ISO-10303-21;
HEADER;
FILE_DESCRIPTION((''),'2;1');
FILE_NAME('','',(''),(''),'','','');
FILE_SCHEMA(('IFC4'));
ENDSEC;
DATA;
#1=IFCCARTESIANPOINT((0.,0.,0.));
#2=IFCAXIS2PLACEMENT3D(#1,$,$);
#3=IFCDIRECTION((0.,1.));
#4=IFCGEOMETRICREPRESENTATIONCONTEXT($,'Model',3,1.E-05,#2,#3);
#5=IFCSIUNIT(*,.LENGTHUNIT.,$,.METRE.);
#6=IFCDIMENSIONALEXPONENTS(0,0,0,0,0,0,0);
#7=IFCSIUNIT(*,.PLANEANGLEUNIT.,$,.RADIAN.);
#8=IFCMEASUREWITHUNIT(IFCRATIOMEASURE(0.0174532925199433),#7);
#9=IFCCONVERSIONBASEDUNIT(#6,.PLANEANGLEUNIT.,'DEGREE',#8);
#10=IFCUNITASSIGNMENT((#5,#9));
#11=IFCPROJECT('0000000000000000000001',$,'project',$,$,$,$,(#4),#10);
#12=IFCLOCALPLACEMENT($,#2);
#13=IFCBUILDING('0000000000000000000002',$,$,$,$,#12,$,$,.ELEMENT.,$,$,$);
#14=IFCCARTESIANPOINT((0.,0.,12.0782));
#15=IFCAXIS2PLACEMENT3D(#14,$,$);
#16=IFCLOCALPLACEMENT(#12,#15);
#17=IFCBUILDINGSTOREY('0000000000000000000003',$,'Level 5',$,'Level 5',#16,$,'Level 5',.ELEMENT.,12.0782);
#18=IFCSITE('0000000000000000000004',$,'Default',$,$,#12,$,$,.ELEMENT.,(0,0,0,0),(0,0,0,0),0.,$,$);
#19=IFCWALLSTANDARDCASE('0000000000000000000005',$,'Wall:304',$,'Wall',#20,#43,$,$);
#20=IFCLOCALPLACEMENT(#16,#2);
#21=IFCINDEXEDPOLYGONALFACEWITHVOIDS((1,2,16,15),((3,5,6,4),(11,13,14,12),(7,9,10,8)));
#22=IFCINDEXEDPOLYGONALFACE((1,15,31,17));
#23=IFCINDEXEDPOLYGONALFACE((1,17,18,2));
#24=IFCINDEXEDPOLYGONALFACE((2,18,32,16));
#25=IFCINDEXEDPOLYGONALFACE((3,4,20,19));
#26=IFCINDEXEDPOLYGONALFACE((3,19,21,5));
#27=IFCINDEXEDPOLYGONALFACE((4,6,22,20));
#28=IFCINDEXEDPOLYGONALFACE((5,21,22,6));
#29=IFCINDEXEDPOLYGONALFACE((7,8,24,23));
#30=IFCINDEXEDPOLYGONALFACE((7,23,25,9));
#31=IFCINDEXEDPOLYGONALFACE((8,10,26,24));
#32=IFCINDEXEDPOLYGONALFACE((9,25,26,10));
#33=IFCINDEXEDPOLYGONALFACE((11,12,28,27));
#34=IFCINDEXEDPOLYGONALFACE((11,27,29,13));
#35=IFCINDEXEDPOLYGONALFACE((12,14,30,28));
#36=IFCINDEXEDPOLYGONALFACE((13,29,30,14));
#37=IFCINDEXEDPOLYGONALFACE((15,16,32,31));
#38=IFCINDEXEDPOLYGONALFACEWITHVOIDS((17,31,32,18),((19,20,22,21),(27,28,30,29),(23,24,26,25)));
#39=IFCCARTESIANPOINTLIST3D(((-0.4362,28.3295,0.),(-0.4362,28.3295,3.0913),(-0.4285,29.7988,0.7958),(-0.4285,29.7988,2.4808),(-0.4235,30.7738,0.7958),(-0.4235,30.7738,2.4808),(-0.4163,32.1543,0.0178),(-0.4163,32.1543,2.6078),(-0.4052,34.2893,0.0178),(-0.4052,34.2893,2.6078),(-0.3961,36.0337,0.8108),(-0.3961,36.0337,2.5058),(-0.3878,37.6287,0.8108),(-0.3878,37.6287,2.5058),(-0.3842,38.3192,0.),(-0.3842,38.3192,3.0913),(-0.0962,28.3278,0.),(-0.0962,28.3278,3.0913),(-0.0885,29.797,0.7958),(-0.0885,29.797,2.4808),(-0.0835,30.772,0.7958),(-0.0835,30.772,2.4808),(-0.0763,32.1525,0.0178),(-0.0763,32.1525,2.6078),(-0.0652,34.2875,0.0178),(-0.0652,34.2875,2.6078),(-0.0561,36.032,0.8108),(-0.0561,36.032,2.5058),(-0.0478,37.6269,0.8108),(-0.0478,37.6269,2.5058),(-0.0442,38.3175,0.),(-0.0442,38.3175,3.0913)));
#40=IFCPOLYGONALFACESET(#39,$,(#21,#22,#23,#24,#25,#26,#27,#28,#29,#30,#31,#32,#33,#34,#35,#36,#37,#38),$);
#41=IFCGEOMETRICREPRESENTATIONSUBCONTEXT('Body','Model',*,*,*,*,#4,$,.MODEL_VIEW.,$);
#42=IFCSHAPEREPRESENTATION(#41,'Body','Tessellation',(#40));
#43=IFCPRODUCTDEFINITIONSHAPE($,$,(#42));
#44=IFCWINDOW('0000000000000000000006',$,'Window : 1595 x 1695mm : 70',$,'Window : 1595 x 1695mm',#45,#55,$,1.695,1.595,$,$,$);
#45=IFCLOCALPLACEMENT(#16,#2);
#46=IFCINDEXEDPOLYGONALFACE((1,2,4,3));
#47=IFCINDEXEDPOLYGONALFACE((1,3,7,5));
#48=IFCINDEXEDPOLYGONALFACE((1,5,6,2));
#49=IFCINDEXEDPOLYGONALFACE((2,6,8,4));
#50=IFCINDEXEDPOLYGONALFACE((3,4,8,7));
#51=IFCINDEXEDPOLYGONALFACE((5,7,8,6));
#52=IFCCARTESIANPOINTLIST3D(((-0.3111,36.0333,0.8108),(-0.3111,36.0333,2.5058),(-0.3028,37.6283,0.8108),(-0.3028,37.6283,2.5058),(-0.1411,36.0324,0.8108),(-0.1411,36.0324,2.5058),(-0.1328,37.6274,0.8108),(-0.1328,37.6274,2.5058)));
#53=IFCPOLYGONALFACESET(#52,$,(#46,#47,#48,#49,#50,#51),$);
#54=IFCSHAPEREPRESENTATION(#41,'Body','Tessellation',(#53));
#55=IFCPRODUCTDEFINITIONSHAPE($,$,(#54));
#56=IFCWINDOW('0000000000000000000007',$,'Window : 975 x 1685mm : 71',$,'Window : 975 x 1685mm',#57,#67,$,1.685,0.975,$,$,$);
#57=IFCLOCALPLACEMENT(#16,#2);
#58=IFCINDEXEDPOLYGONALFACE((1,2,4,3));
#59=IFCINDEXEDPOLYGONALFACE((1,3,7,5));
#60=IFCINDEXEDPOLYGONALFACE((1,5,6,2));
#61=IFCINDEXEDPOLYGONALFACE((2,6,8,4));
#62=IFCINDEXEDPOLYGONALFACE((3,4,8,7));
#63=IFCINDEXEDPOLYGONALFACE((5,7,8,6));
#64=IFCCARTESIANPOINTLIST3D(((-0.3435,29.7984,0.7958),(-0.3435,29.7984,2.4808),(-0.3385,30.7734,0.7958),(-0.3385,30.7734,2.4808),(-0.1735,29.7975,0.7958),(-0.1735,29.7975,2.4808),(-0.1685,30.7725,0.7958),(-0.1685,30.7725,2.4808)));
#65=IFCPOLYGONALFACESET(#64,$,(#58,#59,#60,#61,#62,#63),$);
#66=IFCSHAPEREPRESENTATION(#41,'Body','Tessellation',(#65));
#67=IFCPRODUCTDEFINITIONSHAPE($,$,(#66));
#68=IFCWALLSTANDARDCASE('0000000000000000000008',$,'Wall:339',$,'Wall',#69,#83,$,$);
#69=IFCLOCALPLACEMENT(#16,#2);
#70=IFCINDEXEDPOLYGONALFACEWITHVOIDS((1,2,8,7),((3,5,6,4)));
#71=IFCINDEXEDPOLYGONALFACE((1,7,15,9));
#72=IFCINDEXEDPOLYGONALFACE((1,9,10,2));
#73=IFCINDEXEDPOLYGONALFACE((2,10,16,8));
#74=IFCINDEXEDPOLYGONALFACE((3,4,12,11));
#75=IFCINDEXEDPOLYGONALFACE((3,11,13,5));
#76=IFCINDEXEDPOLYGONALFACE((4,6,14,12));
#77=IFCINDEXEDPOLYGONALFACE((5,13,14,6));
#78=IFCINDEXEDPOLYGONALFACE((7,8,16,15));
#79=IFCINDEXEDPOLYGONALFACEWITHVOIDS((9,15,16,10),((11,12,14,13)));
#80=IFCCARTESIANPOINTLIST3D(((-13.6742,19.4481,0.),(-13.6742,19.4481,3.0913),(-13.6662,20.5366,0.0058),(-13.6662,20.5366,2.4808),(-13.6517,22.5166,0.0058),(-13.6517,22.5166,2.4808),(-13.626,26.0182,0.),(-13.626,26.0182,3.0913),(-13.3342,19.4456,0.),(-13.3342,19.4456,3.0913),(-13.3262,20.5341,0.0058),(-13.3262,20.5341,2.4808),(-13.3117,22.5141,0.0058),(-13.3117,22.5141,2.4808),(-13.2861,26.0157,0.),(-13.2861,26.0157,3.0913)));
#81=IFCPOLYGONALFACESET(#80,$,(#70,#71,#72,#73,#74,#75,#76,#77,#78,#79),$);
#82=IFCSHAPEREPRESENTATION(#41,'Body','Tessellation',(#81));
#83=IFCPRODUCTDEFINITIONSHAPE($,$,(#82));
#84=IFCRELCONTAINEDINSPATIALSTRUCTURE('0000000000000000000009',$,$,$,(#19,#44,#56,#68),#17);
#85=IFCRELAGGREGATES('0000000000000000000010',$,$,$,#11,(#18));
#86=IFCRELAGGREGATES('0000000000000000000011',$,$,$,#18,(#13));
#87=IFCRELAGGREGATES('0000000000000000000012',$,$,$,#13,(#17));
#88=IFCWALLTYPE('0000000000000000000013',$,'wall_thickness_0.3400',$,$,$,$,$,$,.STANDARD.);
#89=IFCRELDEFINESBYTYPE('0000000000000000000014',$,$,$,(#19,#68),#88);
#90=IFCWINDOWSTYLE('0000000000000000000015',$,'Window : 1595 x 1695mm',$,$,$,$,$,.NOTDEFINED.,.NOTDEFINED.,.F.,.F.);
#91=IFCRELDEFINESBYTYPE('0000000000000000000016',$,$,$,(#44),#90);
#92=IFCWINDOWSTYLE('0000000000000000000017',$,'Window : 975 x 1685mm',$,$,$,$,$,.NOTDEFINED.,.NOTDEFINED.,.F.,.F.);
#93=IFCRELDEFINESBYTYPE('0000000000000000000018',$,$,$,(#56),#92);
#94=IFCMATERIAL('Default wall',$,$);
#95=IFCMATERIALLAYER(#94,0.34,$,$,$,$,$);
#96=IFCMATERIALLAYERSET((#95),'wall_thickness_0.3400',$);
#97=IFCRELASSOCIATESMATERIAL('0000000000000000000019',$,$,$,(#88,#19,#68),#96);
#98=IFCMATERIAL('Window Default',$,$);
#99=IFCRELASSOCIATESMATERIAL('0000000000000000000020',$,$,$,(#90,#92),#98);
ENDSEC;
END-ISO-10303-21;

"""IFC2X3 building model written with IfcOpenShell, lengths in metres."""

from ifc_helpers import new_model, entity, si_unit, converted_unit, direction, frame, frame_2d, origin, origin_2d_with_axis, place, context, subcontext, project, spatial, polyline, rectangle, outline, extrude, clip, halfspace, source, transform, mapped, material, layer, layer_set, layer_usage, type_object, type_shapes, element, fill, save


model = new_model("IFC2X3")

# Units and contexts
model_context = context("Model", 3, precision=1e-05, world=origin(), true_north=direction((0.0, 1.0)))
body_context = subcontext(model_context, "Body", "Model", "MODEL_VIEW")
ifc_project = project(units=[si_unit("LENGTHUNIT", "METRE"), converted_unit("PLANEANGLEUNIT", "DEGREE", entity("IfcRatioMeasure", 0.0174532925199433), si_unit("PLANEANGLEUNIT", "RADIAN"), dimensions=[0, 0, 0, 0, 0, 0, 0])], contexts=[model_context])

# Site, building, storey
placement_1 = place(None, origin())
site = spatial("IfcSite", under=ifc_project, at=placement_1, Name="Default", CompositionType="ELEMENT", RefLatitude=(0, 0, 0, 0), RefLongitude=(0, 0, 0, 0), RefElevation=0.0)
building = spatial("IfcBuilding", under=site, at=placement_1, CompositionType="ELEMENT")
storey_placement = place(placement_1, frame((0.0, 0.0, 12.0782)))
storey = spatial("IfcBuildingStorey", under=building, at=storey_placement, Name="Level 5", ObjectType="Level 5", LongName="Level 5", CompositionType="ELEMENT", Elevation=12.0782)

# Shared definitions
ifc_material_1 = material(Name="Default wall")
ifc_material_2 = material(Name="Window Default")

# Wall, openings, windows
ifc_layer_1 = layer(ifc_material_1, 0.34)
ifc_layer_set_1 = layer_set([ifc_layer_1], Name="wall_thickness_0.3400")
ifc_layer_usage_1 = layer_usage(ifc_layer_set_1, "AXIS2", "POSITIVE", -0.17)
wall_type_1 = type_object("IfcWallType", Name="wall_thickness_0.3400", PredefinedType="STANDARD", material=ifc_layer_set_1)
wall_1_placement = place(storey_placement, frame((-0.2142, 38.3183, 0.0), z_axis=(0.0, 0.0, 1.0), x_axis=(-0.005204, -0.999986, 0.0)))
wall_1 = element("IfcWallStandardCase", 1, at=wall_1_placement, inside=storey, type_object=wall_type_1, material=ifc_layer_usage_1, Name="Wall:304", ObjectType="Wall", context=body_context, shape_type="Clipping", body=[
    clip(extrude(outline(polyline([(9.9898, -0.17), (9.9898, 0.17), (0.0, 0.17), (0.0, -0.17), (9.9898, -0.17)])), origin(), (0.0, 0.0, 1.0), 3.0913), halfspace(frame((-37.5236, -1.2077, 4.0083), z_axis=(0.000614, -0.389903, 0.920856), x_axis=(0.000761, 0.920855, 0.389905)), False)),
])
opening_1_placement = place(wall_1_placement, frame((4.03, -0.17, 0.0178)))
element("IfcOpeningElement", 2, at=opening_1_placement, cuts=wall_1, ObjectType="Opening", context=body_context, shape_type="SweptSolid", body=[
    extrude(rectangle(XDim=2.135, YDim=2.59, at=frame_2d((1.295, 1.0675), x_axis=(0.0, 1.0))), frame((0.0, 0.0, 0.0), z_axis=(0.0, 1.0, 0.0), x_axis=(0.0, 0.0, 1.0)), (0.0, 0.0, 1.0), 0.34),
])
opening_2_placement = place(wall_1_placement, frame((0.6905, -0.17, 0.8108)))
opening_2 = element("IfcOpeningElement", 3, at=opening_2_placement, cuts=wall_1, ObjectType="Opening", context=body_context, shape_type="SweptSolid", body=[
    extrude(rectangle(XDim=1.595, YDim=1.695, at=frame_2d((0.8475, 0.7975), x_axis=(0.0, 1.0))), frame((0.0, 0.0, 0.0), z_axis=(0.0, 1.0, 0.0), x_axis=(0.0, 0.0, 1.0)), (0.0, 0.0, 1.0), 0.34),
])
opening_3_placement = place(wall_1_placement, frame((7.5455, -0.17, 0.7958)))
opening_3 = element("IfcOpeningElement", 4, at=opening_3_placement, cuts=wall_1, ObjectType="Opening", context=body_context, shape_type="SweptSolid", body=[
    extrude(rectangle(XDim=0.975, YDim=1.685, at=frame_2d((0.8425, 0.4875), x_axis=(0.0, 1.0))), frame((0.0, 0.0, 0.0), z_axis=(0.0, 1.0, 0.0), x_axis=(0.0, 0.0, 1.0)), (0.0, 0.0, 1.0), 0.34),
])
window_style_1 = type_object("IfcWindowStyle", Name="Window : 1595 x 1695mm", ConstructionType="NOTDEFINED", OperationType="NOTDEFINED", ParameterTakesPrecedence=False, Sizeable=False, material=ifc_material_2)
shared_shape_1 = source(origin(), body_context, "Body", "SweptSolid", [
    extrude(rectangle(XDim=0.17, YDim=1.595, at=origin_2d_with_axis()), frame((0.7975, 0.17, 0.0), z_axis=(0.0, 0.0, 1.0), x_axis=(0.0, 1.0, 0.0)), (0.0, 0.0, 1.0), 1.695),
])
type_shapes(window_style_1, [shared_shape_1])
window_1_placement = place(opening_2_placement, origin())
window_1 = element("IfcWindow", 5, at=window_1_placement, inside=storey, type_object=window_style_1, Name="Window : 1595 x 1695mm : 70", ObjectType="Window : 1595 x 1695mm", OverallHeight=1.695, OverallWidth=1.595, context=body_context, shape_type="MappedRepresentation", body=[
    mapped(shared_shape_1, transform((0.0, 0.0, 0.0), scale=1.0)),
])
fill(opening_2, window_1)
window_style_2 = type_object("IfcWindowStyle", Name="Window : 975 x 1685mm", ConstructionType="NOTDEFINED", OperationType="NOTDEFINED", ParameterTakesPrecedence=False, Sizeable=False, material=ifc_material_2)
shared_shape_2 = source(origin(), body_context, "Body", "SweptSolid", [
    extrude(rectangle(XDim=0.17, YDim=0.975, at=origin_2d_with_axis()), frame((0.4875, 0.17, 0.0), z_axis=(0.0, 0.0, 1.0), x_axis=(0.0, 1.0, 0.0)), (0.0, 0.0, 1.0), 1.685),
])
type_shapes(window_style_2, [shared_shape_2])
window_2_placement = place(opening_3_placement, origin())
window_2 = element("IfcWindow", 6, at=window_2_placement, inside=storey, type_object=window_style_2, Name="Window : 975 x 1685mm : 71", ObjectType="Window : 975 x 1685mm", OverallHeight=1.685, OverallWidth=0.975, context=body_context, shape_type="MappedRepresentation", body=[
    mapped(shared_shape_2, transform((0.0, 0.0, 0.0), scale=1.0)),
])
fill(opening_3, window_2)

# Wall, opening
wall_2_placement = place(storey_placement, frame((-13.456, 26.0169, 0.0), z_axis=(0.0, 0.0, 1.0), x_axis=(-0.007323, -0.999973, 0.0)))
wall_2 = element("IfcWallStandardCase", 7, at=wall_2_placement, inside=storey, type_object=wall_type_1, material=ifc_layer_usage_1, Name="Wall:339", ObjectType="Wall", context=body_context, shape_type="SweptSolid", body=[
    extrude(outline(polyline([(6.5703, -0.17), (6.5703, 0.17), (0.0, 0.17), (0.0, -0.17), (6.5703, -0.17)])), origin(), (0.0, 0.0, 1.0), 3.0913),
])
opening_4_placement = place(wall_2_placement, frame((3.5017, -0.17, 0.0058)))
element("IfcOpeningElement", 8, at=opening_4_placement, cuts=wall_2, ObjectType="Opening", context=body_context, shape_type="SweptSolid", body=[
    extrude(rectangle(XDim=1.98, YDim=2.475, at=frame_2d((1.2375, 0.99), x_axis=(0.0, 1.0))), frame((0.0, 0.0, 0.0), z_axis=(0.0, 1.0, 0.0), x_axis=(0.0, 0.0, 1.0)), (0.0, 0.0, 1.0), 0.34),
])

save(model, "model.ifc")
